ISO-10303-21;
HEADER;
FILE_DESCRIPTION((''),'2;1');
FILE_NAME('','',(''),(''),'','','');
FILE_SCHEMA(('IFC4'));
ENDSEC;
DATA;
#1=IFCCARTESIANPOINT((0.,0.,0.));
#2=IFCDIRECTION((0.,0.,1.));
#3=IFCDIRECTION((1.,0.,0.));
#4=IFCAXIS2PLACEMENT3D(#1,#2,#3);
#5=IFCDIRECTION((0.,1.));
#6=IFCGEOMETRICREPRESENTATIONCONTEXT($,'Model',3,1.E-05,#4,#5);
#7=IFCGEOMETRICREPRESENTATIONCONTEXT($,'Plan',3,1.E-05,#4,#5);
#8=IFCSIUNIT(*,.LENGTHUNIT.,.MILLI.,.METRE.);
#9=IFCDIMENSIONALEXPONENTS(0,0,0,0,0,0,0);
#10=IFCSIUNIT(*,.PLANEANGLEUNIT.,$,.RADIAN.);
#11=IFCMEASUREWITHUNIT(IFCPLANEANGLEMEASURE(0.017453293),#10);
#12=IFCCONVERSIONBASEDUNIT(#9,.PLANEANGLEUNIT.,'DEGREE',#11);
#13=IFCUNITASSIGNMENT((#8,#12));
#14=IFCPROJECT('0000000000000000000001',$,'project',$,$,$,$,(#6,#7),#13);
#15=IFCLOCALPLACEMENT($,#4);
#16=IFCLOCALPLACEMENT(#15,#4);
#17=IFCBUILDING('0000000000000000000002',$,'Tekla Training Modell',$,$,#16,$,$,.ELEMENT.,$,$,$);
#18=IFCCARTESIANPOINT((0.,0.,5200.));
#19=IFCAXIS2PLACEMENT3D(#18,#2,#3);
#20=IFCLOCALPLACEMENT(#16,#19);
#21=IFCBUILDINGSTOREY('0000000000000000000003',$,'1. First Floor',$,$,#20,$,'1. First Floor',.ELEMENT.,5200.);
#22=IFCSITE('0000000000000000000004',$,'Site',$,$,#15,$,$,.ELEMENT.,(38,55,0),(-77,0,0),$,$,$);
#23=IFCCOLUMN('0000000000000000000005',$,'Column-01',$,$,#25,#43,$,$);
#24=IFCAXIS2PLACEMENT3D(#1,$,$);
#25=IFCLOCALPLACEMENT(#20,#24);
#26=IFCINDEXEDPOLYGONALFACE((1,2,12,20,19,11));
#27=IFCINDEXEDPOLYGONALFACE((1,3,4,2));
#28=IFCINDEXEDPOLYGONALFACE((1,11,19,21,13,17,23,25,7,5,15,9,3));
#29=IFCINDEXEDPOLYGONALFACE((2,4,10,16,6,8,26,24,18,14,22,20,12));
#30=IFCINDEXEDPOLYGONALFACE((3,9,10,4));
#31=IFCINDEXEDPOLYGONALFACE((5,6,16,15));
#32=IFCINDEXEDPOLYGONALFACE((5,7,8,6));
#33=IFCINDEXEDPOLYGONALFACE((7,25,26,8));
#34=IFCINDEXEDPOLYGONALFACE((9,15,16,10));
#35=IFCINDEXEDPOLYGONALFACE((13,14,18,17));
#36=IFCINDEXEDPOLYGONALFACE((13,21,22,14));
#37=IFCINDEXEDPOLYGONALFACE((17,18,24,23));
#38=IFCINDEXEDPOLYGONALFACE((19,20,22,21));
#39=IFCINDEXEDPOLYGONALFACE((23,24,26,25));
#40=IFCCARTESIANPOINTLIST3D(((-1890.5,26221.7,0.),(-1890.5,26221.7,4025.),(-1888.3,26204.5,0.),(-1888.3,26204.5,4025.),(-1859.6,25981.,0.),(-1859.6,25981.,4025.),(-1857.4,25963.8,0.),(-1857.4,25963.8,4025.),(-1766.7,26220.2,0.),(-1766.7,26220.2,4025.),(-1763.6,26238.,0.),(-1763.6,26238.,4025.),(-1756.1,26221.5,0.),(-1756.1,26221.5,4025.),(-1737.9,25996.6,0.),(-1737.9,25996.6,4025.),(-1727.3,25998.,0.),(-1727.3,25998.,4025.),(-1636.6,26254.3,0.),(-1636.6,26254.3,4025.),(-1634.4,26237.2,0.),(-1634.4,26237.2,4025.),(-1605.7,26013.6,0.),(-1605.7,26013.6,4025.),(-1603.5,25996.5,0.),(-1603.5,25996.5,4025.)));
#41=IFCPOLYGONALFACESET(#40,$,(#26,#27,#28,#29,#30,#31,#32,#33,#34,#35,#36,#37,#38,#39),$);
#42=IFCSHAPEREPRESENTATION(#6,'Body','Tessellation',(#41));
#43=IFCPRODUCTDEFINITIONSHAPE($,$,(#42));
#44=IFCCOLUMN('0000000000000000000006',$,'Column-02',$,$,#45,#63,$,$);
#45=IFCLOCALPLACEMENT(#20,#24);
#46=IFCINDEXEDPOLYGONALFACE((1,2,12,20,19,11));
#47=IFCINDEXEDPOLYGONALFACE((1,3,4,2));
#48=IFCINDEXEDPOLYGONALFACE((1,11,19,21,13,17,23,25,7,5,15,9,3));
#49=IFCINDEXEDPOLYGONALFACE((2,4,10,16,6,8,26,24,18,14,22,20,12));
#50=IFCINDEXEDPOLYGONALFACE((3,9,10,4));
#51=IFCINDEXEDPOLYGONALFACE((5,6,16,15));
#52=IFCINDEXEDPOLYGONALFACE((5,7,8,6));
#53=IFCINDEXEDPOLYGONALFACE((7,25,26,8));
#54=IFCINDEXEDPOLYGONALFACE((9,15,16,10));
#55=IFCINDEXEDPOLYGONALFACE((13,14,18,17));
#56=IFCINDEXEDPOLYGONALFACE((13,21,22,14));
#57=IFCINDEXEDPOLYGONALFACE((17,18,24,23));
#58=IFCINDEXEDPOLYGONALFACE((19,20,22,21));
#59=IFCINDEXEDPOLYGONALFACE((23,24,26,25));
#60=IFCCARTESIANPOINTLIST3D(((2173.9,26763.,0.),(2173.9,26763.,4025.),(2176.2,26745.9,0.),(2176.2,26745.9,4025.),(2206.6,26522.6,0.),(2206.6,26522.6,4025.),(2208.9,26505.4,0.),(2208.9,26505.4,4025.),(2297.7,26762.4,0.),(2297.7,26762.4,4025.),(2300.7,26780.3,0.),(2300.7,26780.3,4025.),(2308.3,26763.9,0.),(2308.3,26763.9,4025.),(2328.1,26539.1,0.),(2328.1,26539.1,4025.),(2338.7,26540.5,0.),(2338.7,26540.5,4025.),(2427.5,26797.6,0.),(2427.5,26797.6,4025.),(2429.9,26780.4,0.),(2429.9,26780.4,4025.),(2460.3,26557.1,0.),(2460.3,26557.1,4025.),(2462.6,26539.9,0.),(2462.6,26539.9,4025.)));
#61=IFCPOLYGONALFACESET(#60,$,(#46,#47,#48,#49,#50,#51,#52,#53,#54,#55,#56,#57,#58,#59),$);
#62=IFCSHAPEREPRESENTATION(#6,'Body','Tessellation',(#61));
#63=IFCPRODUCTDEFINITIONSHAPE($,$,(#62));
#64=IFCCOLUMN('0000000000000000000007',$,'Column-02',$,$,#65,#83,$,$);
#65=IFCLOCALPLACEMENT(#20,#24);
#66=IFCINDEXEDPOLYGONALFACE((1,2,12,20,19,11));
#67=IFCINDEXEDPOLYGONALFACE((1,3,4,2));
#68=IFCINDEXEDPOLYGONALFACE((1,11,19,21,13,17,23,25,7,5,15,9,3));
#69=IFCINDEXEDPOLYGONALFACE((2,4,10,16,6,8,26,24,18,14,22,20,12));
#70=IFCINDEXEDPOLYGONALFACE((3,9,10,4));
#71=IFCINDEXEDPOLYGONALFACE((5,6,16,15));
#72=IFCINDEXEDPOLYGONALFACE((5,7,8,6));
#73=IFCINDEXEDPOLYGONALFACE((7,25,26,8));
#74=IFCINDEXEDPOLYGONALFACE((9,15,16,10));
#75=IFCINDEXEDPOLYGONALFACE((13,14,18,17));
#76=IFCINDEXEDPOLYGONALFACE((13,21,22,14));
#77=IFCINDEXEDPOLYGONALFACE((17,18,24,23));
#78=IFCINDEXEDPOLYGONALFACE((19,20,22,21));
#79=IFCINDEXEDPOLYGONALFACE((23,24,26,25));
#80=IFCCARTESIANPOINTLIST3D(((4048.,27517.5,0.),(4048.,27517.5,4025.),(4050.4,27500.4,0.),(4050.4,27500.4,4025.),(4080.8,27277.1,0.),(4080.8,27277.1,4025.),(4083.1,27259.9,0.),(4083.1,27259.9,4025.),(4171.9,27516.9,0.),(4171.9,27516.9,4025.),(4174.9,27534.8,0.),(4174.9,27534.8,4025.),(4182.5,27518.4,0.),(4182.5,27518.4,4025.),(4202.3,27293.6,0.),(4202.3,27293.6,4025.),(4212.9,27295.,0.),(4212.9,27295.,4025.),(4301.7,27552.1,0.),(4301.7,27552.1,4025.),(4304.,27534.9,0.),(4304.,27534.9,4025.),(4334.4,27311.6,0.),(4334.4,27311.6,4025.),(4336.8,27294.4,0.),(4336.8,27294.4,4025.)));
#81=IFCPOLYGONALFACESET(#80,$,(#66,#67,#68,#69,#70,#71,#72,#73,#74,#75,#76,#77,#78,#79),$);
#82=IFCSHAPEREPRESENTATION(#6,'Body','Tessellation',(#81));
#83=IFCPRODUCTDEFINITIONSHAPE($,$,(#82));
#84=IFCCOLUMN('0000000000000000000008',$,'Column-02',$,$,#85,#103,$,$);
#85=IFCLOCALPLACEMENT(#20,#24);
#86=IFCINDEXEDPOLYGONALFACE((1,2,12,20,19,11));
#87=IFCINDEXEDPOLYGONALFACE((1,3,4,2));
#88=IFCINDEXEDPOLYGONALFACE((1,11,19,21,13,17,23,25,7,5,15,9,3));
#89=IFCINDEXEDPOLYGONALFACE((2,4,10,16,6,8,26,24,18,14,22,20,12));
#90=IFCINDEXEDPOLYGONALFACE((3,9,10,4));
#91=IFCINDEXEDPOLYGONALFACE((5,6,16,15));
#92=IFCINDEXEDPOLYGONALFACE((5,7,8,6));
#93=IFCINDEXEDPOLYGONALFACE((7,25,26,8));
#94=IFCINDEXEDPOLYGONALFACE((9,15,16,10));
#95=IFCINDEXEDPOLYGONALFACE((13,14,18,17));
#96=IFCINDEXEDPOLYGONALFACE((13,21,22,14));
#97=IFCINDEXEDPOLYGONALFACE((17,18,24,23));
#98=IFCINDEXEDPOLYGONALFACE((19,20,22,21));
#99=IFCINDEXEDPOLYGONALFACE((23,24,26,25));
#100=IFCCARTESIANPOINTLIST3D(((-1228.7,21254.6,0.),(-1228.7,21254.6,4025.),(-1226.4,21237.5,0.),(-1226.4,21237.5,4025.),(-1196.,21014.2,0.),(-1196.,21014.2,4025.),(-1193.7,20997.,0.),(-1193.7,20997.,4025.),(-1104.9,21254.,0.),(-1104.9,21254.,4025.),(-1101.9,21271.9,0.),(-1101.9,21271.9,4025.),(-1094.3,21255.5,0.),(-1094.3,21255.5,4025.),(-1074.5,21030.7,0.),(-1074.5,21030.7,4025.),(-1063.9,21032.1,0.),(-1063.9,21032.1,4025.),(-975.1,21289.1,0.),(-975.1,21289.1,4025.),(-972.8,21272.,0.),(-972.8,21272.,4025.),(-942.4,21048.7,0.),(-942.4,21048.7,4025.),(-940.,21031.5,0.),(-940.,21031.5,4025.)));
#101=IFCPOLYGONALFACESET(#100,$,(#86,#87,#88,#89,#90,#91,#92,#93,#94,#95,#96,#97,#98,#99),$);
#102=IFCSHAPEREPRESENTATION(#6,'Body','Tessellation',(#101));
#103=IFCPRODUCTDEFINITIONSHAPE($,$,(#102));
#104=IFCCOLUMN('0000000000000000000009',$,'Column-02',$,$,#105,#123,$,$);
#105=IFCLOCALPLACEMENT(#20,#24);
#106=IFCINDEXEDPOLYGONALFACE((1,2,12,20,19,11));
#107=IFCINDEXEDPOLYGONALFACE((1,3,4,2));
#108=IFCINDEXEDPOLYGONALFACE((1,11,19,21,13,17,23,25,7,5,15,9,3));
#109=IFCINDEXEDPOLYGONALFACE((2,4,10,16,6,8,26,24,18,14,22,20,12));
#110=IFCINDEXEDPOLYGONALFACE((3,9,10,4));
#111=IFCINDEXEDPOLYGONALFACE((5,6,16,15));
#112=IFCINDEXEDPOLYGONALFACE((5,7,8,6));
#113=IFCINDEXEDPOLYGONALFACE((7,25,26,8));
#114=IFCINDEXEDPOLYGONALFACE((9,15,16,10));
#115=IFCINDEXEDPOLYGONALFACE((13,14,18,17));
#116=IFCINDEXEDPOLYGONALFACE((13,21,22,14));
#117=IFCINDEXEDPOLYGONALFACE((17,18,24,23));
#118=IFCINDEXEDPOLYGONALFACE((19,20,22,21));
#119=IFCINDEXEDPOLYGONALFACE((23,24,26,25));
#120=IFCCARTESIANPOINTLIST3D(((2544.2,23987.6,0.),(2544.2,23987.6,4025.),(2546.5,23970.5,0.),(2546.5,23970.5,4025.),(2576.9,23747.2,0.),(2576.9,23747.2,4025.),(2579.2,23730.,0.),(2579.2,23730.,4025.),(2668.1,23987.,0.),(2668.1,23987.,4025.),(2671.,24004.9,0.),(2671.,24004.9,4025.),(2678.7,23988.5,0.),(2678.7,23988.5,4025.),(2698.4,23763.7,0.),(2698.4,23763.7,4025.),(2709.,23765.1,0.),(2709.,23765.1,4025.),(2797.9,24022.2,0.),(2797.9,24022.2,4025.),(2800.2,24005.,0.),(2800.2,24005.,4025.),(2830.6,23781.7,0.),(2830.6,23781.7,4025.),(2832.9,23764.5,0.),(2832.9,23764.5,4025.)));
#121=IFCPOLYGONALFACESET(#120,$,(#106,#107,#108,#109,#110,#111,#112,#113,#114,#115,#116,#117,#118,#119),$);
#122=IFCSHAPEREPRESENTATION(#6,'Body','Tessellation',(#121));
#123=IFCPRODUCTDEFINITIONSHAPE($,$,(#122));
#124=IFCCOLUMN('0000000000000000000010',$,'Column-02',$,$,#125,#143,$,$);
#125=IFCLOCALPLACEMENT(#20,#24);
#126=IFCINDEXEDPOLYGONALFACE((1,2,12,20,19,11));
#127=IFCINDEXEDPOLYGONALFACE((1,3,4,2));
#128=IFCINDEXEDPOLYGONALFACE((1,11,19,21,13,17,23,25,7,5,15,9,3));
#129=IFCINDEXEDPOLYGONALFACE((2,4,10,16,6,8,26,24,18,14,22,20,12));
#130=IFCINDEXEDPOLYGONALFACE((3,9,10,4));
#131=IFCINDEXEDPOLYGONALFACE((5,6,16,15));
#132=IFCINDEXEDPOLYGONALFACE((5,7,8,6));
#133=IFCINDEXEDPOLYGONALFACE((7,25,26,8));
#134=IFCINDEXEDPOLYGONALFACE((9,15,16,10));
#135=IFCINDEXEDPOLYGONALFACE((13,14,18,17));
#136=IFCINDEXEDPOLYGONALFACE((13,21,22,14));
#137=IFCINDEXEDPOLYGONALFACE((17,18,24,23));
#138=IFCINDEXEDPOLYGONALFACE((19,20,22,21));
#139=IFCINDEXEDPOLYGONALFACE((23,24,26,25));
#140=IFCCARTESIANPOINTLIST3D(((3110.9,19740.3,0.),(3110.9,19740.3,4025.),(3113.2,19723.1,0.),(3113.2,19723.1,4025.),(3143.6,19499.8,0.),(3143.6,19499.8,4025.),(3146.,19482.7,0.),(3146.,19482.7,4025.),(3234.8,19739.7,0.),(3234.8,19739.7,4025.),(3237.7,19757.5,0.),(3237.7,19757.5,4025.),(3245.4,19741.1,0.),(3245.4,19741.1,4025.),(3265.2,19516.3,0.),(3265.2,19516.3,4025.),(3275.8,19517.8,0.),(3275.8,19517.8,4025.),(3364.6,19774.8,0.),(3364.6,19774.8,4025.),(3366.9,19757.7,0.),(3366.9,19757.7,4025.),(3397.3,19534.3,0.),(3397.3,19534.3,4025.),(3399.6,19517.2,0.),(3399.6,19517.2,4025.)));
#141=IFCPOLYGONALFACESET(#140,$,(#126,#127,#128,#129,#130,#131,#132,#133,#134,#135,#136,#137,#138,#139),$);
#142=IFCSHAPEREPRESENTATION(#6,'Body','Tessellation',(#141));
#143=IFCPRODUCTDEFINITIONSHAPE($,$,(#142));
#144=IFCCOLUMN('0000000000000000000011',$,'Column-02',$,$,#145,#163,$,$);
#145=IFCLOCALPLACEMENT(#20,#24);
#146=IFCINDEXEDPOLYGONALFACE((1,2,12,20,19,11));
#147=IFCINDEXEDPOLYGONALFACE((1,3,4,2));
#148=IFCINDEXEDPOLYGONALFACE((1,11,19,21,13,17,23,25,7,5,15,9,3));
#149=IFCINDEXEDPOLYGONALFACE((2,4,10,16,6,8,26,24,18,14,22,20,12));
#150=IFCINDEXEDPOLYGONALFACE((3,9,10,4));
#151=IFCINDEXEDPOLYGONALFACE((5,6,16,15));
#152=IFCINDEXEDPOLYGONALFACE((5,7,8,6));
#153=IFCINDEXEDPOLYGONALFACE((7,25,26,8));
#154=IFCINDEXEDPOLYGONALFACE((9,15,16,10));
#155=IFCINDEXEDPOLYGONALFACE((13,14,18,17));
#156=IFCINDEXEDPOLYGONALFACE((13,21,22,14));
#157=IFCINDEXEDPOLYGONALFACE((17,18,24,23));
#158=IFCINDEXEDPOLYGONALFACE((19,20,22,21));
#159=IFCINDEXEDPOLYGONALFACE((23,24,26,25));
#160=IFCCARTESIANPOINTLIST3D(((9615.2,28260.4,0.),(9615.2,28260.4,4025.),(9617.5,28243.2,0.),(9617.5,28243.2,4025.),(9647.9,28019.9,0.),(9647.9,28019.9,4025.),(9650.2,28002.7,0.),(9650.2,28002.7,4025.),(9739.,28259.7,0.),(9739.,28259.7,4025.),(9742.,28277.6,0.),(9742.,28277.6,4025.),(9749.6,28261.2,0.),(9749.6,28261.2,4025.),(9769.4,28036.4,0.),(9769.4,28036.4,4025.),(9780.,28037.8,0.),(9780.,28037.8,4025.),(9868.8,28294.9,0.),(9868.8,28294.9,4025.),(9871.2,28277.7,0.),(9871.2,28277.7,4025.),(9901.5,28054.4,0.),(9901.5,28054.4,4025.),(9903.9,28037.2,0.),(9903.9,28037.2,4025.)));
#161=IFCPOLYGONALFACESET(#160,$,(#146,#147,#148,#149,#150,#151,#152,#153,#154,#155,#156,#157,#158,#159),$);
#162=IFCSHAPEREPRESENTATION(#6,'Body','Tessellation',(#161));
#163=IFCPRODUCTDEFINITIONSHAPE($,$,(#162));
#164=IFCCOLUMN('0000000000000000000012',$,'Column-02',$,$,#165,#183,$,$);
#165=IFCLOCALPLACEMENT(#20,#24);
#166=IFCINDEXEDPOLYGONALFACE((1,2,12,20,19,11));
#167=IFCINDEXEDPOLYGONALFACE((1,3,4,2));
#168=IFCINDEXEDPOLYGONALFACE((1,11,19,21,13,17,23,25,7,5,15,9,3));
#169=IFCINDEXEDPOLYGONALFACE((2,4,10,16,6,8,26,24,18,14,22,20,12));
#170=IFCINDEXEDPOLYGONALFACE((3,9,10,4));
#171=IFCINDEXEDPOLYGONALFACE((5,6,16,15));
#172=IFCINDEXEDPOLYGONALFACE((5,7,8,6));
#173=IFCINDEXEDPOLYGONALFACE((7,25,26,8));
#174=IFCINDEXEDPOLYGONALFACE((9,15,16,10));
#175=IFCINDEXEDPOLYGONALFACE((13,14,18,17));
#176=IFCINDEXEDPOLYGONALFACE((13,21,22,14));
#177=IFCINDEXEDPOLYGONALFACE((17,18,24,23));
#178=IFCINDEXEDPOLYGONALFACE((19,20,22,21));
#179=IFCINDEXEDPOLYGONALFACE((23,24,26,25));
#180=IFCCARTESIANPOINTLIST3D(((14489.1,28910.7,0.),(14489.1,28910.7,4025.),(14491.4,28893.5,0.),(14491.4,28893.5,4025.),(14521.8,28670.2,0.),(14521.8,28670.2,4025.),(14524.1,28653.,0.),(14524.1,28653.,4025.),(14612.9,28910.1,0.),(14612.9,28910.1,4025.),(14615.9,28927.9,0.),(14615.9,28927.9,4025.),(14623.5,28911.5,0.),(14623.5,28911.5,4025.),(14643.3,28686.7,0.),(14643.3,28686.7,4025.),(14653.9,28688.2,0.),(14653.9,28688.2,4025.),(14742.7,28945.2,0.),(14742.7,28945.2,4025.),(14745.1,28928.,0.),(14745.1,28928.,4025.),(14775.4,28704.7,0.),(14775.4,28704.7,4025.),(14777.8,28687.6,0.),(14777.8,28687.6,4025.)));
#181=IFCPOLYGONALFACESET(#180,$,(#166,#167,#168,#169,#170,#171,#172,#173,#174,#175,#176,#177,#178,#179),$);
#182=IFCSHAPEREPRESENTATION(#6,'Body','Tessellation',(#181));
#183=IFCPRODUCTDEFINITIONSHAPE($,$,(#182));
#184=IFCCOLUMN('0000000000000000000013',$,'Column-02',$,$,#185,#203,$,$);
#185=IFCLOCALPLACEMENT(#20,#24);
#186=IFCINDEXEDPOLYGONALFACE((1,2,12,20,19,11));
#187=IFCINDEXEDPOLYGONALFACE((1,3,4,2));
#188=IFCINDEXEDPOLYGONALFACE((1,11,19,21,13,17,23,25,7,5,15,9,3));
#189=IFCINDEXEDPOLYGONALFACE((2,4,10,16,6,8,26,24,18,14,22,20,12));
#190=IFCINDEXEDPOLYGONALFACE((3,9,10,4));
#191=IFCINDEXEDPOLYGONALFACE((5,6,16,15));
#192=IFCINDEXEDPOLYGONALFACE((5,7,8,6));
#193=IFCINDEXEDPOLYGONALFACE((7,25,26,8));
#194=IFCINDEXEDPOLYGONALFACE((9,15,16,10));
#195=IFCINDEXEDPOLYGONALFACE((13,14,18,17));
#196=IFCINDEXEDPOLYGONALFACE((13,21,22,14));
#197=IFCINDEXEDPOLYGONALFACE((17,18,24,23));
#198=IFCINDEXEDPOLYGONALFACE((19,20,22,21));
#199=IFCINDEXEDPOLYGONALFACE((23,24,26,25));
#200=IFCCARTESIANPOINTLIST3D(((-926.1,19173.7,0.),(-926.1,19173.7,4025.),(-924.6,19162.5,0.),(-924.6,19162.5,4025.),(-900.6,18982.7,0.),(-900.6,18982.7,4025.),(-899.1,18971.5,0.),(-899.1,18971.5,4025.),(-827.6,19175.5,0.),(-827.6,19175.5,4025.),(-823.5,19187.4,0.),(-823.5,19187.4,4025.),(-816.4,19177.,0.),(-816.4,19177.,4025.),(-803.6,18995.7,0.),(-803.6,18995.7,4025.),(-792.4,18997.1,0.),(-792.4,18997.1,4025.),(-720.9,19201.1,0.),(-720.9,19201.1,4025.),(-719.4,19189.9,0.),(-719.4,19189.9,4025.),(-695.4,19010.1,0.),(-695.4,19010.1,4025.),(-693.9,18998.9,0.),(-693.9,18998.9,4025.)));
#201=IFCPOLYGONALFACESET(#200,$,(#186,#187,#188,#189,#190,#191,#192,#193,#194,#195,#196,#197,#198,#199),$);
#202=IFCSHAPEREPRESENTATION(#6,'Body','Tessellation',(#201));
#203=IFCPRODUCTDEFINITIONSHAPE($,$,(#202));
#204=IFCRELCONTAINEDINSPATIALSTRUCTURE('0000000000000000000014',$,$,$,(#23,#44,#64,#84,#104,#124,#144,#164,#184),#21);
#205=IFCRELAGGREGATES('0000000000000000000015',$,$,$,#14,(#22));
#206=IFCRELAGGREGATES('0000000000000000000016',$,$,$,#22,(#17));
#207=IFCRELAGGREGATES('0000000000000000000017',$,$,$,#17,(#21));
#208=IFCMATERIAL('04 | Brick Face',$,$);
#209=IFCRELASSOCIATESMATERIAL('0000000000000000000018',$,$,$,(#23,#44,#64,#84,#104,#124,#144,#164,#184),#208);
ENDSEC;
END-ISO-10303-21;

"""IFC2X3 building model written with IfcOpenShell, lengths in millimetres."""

from ifc_helpers import new_model, entity, si_unit, converted_unit, direction, frame, origin_with_axes, place, context, project, spatial, polyline, outline, extrude, material, element, save


model = new_model("IFC2X3")

# Units and contexts
model_context = context("Model", 3, precision=1e-05, world=origin_with_axes(), true_north=direction((0.0, 1.0)))
plan_context = context("Plan", 3, precision=1e-05, world=origin_with_axes(), true_north=direction((0.0, 1.0)))
ifc_project = project(units=[si_unit("LENGTHUNIT", "METRE", prefix="MILLI"), converted_unit("PLANEANGLEUNIT", "DEGREE", entity("IfcPlaneAngleMeasure", 0.017453293), si_unit("PLANEANGLEUNIT", "RADIAN"), dimensions=[0, 0, 0, 0, 0, 0, 0])], contexts=[model_context, plan_context])

# Site, building, storey
site_placement = place(None, origin_with_axes())
site = spatial("IfcSite", under=ifc_project, at=site_placement, Name="Site", CompositionType="ELEMENT", RefLatitude=(38, 55, 0), RefLongitude=(-77, 0, 0))
building_placement = place(site_placement, origin_with_axes())
building = spatial("IfcBuilding", under=site, at=building_placement, Name="Tekla Training Modell", CompositionType="ELEMENT")
storey_placement = place(building_placement, frame((0.0, 0.0, 5200.0), z_axis=(0.0, 0.0, 1.0), x_axis=(1.0, 0.0, 0.0)))
storey = spatial("IfcBuildingStorey", under=building, at=storey_placement, Name="1. First Floor", LongName="1. First Floor", CompositionType="ELEMENT", Elevation=5200.0)

# Columns
ifc_material_1 = material(Name="04 | Brick Face")
for number, where, z_axis, x_axis, name in (
    (1, (-1747.0, 26109.1, 0.0), (0.0, 0.0, 1.0), (0.991827, 0.127587, 0.0), "Column-01"),
    (2, (2318.2, 26651.5, 0.0), (0.0, 0.0, 1.0), (0.990872, 0.134803, 0.0), "Column-02"),
    (3, (4192.4, 27406.0, 0.0), (0.0, 0.0, 1.0), (0.990872, 0.134803, 0.0), "Column-02"),
    (4, (-1084.4, 21143.1, 0.0), (0.0, 0.0, 1.0), (0.990872, 0.134803, 0.0), "Column-02"),
    (5, (2688.5, 23876.1, 0.0), (0.0, 0.0, 1.0), (0.990872, 0.134803, 0.0), "Column-02"),
    (6, (3255.3, 19628.7, 0.0), (0.0, 0.0, 1.0), (0.990872, 0.134803, 0.0), "Column-02"),
    (7, (9759.5, 28148.8, 0.0), (0.0, 0.0, 1.0), (0.990872, 0.134803, 0.0), "Column-02"),
    (8, (14633.4, 28799.1, 0.0), (0.0, 0.0, 1.0), (0.990872, 0.134803, 0.0), "Column-02"),
):
    element("IfcColumn", number, at=place(storey_placement, frame(where, z_axis=z_axis, x_axis=x_axis)), inside=storey, material=ifc_material_1, Name=name, context=model_context, shape_type="SweptSolid", body=[
        extrude(outline(polyline([(0.0, 130.0), (-128.0, 130.0), (-128.0, 112.7), (-5.3, 112.7), (-5.3, -112.7), (-128.0, -112.7), (-128.0, -130.0), (128.0, -130.0), (128.0, -112.7), (5.3, -112.7), (5.3, 112.7), (128.0, 112.7), (128.0, 130.0), (0.0, 130.0)])), origin_with_axes(), (0.0, 0.0, 1.0), 4025.0),
    ])
column_placement = place(storey_placement, frame((-810.0, 19086.3, 0.0), z_axis=(0.0, 0.0, 1.0), x_axis=(0.991216, 0.132256, 0.0)))
element("IfcColumn", 9, at=column_placement, inside=storey, material=ifc_material_1, Name="Column-02", context=model_context, shape_type="SweptSolid", body=[
    extrude(outline(polyline([(0.0, 102.0), (-103.5, 102.0), (-103.5, 90.7), (-5.7, 90.7), (-5.7, -90.7), (-103.5, -90.7), (-103.5, -102.0), (103.5, -102.0), (103.5, -90.7), (5.7, -90.7), (5.7, 90.7), (103.5, 90.7), (103.5, 102.0), (0.0, 102.0)])), origin_with_axes(), (0.0, 0.0, 1.0), 4025.0),
])

save(model, "model.ifc")
